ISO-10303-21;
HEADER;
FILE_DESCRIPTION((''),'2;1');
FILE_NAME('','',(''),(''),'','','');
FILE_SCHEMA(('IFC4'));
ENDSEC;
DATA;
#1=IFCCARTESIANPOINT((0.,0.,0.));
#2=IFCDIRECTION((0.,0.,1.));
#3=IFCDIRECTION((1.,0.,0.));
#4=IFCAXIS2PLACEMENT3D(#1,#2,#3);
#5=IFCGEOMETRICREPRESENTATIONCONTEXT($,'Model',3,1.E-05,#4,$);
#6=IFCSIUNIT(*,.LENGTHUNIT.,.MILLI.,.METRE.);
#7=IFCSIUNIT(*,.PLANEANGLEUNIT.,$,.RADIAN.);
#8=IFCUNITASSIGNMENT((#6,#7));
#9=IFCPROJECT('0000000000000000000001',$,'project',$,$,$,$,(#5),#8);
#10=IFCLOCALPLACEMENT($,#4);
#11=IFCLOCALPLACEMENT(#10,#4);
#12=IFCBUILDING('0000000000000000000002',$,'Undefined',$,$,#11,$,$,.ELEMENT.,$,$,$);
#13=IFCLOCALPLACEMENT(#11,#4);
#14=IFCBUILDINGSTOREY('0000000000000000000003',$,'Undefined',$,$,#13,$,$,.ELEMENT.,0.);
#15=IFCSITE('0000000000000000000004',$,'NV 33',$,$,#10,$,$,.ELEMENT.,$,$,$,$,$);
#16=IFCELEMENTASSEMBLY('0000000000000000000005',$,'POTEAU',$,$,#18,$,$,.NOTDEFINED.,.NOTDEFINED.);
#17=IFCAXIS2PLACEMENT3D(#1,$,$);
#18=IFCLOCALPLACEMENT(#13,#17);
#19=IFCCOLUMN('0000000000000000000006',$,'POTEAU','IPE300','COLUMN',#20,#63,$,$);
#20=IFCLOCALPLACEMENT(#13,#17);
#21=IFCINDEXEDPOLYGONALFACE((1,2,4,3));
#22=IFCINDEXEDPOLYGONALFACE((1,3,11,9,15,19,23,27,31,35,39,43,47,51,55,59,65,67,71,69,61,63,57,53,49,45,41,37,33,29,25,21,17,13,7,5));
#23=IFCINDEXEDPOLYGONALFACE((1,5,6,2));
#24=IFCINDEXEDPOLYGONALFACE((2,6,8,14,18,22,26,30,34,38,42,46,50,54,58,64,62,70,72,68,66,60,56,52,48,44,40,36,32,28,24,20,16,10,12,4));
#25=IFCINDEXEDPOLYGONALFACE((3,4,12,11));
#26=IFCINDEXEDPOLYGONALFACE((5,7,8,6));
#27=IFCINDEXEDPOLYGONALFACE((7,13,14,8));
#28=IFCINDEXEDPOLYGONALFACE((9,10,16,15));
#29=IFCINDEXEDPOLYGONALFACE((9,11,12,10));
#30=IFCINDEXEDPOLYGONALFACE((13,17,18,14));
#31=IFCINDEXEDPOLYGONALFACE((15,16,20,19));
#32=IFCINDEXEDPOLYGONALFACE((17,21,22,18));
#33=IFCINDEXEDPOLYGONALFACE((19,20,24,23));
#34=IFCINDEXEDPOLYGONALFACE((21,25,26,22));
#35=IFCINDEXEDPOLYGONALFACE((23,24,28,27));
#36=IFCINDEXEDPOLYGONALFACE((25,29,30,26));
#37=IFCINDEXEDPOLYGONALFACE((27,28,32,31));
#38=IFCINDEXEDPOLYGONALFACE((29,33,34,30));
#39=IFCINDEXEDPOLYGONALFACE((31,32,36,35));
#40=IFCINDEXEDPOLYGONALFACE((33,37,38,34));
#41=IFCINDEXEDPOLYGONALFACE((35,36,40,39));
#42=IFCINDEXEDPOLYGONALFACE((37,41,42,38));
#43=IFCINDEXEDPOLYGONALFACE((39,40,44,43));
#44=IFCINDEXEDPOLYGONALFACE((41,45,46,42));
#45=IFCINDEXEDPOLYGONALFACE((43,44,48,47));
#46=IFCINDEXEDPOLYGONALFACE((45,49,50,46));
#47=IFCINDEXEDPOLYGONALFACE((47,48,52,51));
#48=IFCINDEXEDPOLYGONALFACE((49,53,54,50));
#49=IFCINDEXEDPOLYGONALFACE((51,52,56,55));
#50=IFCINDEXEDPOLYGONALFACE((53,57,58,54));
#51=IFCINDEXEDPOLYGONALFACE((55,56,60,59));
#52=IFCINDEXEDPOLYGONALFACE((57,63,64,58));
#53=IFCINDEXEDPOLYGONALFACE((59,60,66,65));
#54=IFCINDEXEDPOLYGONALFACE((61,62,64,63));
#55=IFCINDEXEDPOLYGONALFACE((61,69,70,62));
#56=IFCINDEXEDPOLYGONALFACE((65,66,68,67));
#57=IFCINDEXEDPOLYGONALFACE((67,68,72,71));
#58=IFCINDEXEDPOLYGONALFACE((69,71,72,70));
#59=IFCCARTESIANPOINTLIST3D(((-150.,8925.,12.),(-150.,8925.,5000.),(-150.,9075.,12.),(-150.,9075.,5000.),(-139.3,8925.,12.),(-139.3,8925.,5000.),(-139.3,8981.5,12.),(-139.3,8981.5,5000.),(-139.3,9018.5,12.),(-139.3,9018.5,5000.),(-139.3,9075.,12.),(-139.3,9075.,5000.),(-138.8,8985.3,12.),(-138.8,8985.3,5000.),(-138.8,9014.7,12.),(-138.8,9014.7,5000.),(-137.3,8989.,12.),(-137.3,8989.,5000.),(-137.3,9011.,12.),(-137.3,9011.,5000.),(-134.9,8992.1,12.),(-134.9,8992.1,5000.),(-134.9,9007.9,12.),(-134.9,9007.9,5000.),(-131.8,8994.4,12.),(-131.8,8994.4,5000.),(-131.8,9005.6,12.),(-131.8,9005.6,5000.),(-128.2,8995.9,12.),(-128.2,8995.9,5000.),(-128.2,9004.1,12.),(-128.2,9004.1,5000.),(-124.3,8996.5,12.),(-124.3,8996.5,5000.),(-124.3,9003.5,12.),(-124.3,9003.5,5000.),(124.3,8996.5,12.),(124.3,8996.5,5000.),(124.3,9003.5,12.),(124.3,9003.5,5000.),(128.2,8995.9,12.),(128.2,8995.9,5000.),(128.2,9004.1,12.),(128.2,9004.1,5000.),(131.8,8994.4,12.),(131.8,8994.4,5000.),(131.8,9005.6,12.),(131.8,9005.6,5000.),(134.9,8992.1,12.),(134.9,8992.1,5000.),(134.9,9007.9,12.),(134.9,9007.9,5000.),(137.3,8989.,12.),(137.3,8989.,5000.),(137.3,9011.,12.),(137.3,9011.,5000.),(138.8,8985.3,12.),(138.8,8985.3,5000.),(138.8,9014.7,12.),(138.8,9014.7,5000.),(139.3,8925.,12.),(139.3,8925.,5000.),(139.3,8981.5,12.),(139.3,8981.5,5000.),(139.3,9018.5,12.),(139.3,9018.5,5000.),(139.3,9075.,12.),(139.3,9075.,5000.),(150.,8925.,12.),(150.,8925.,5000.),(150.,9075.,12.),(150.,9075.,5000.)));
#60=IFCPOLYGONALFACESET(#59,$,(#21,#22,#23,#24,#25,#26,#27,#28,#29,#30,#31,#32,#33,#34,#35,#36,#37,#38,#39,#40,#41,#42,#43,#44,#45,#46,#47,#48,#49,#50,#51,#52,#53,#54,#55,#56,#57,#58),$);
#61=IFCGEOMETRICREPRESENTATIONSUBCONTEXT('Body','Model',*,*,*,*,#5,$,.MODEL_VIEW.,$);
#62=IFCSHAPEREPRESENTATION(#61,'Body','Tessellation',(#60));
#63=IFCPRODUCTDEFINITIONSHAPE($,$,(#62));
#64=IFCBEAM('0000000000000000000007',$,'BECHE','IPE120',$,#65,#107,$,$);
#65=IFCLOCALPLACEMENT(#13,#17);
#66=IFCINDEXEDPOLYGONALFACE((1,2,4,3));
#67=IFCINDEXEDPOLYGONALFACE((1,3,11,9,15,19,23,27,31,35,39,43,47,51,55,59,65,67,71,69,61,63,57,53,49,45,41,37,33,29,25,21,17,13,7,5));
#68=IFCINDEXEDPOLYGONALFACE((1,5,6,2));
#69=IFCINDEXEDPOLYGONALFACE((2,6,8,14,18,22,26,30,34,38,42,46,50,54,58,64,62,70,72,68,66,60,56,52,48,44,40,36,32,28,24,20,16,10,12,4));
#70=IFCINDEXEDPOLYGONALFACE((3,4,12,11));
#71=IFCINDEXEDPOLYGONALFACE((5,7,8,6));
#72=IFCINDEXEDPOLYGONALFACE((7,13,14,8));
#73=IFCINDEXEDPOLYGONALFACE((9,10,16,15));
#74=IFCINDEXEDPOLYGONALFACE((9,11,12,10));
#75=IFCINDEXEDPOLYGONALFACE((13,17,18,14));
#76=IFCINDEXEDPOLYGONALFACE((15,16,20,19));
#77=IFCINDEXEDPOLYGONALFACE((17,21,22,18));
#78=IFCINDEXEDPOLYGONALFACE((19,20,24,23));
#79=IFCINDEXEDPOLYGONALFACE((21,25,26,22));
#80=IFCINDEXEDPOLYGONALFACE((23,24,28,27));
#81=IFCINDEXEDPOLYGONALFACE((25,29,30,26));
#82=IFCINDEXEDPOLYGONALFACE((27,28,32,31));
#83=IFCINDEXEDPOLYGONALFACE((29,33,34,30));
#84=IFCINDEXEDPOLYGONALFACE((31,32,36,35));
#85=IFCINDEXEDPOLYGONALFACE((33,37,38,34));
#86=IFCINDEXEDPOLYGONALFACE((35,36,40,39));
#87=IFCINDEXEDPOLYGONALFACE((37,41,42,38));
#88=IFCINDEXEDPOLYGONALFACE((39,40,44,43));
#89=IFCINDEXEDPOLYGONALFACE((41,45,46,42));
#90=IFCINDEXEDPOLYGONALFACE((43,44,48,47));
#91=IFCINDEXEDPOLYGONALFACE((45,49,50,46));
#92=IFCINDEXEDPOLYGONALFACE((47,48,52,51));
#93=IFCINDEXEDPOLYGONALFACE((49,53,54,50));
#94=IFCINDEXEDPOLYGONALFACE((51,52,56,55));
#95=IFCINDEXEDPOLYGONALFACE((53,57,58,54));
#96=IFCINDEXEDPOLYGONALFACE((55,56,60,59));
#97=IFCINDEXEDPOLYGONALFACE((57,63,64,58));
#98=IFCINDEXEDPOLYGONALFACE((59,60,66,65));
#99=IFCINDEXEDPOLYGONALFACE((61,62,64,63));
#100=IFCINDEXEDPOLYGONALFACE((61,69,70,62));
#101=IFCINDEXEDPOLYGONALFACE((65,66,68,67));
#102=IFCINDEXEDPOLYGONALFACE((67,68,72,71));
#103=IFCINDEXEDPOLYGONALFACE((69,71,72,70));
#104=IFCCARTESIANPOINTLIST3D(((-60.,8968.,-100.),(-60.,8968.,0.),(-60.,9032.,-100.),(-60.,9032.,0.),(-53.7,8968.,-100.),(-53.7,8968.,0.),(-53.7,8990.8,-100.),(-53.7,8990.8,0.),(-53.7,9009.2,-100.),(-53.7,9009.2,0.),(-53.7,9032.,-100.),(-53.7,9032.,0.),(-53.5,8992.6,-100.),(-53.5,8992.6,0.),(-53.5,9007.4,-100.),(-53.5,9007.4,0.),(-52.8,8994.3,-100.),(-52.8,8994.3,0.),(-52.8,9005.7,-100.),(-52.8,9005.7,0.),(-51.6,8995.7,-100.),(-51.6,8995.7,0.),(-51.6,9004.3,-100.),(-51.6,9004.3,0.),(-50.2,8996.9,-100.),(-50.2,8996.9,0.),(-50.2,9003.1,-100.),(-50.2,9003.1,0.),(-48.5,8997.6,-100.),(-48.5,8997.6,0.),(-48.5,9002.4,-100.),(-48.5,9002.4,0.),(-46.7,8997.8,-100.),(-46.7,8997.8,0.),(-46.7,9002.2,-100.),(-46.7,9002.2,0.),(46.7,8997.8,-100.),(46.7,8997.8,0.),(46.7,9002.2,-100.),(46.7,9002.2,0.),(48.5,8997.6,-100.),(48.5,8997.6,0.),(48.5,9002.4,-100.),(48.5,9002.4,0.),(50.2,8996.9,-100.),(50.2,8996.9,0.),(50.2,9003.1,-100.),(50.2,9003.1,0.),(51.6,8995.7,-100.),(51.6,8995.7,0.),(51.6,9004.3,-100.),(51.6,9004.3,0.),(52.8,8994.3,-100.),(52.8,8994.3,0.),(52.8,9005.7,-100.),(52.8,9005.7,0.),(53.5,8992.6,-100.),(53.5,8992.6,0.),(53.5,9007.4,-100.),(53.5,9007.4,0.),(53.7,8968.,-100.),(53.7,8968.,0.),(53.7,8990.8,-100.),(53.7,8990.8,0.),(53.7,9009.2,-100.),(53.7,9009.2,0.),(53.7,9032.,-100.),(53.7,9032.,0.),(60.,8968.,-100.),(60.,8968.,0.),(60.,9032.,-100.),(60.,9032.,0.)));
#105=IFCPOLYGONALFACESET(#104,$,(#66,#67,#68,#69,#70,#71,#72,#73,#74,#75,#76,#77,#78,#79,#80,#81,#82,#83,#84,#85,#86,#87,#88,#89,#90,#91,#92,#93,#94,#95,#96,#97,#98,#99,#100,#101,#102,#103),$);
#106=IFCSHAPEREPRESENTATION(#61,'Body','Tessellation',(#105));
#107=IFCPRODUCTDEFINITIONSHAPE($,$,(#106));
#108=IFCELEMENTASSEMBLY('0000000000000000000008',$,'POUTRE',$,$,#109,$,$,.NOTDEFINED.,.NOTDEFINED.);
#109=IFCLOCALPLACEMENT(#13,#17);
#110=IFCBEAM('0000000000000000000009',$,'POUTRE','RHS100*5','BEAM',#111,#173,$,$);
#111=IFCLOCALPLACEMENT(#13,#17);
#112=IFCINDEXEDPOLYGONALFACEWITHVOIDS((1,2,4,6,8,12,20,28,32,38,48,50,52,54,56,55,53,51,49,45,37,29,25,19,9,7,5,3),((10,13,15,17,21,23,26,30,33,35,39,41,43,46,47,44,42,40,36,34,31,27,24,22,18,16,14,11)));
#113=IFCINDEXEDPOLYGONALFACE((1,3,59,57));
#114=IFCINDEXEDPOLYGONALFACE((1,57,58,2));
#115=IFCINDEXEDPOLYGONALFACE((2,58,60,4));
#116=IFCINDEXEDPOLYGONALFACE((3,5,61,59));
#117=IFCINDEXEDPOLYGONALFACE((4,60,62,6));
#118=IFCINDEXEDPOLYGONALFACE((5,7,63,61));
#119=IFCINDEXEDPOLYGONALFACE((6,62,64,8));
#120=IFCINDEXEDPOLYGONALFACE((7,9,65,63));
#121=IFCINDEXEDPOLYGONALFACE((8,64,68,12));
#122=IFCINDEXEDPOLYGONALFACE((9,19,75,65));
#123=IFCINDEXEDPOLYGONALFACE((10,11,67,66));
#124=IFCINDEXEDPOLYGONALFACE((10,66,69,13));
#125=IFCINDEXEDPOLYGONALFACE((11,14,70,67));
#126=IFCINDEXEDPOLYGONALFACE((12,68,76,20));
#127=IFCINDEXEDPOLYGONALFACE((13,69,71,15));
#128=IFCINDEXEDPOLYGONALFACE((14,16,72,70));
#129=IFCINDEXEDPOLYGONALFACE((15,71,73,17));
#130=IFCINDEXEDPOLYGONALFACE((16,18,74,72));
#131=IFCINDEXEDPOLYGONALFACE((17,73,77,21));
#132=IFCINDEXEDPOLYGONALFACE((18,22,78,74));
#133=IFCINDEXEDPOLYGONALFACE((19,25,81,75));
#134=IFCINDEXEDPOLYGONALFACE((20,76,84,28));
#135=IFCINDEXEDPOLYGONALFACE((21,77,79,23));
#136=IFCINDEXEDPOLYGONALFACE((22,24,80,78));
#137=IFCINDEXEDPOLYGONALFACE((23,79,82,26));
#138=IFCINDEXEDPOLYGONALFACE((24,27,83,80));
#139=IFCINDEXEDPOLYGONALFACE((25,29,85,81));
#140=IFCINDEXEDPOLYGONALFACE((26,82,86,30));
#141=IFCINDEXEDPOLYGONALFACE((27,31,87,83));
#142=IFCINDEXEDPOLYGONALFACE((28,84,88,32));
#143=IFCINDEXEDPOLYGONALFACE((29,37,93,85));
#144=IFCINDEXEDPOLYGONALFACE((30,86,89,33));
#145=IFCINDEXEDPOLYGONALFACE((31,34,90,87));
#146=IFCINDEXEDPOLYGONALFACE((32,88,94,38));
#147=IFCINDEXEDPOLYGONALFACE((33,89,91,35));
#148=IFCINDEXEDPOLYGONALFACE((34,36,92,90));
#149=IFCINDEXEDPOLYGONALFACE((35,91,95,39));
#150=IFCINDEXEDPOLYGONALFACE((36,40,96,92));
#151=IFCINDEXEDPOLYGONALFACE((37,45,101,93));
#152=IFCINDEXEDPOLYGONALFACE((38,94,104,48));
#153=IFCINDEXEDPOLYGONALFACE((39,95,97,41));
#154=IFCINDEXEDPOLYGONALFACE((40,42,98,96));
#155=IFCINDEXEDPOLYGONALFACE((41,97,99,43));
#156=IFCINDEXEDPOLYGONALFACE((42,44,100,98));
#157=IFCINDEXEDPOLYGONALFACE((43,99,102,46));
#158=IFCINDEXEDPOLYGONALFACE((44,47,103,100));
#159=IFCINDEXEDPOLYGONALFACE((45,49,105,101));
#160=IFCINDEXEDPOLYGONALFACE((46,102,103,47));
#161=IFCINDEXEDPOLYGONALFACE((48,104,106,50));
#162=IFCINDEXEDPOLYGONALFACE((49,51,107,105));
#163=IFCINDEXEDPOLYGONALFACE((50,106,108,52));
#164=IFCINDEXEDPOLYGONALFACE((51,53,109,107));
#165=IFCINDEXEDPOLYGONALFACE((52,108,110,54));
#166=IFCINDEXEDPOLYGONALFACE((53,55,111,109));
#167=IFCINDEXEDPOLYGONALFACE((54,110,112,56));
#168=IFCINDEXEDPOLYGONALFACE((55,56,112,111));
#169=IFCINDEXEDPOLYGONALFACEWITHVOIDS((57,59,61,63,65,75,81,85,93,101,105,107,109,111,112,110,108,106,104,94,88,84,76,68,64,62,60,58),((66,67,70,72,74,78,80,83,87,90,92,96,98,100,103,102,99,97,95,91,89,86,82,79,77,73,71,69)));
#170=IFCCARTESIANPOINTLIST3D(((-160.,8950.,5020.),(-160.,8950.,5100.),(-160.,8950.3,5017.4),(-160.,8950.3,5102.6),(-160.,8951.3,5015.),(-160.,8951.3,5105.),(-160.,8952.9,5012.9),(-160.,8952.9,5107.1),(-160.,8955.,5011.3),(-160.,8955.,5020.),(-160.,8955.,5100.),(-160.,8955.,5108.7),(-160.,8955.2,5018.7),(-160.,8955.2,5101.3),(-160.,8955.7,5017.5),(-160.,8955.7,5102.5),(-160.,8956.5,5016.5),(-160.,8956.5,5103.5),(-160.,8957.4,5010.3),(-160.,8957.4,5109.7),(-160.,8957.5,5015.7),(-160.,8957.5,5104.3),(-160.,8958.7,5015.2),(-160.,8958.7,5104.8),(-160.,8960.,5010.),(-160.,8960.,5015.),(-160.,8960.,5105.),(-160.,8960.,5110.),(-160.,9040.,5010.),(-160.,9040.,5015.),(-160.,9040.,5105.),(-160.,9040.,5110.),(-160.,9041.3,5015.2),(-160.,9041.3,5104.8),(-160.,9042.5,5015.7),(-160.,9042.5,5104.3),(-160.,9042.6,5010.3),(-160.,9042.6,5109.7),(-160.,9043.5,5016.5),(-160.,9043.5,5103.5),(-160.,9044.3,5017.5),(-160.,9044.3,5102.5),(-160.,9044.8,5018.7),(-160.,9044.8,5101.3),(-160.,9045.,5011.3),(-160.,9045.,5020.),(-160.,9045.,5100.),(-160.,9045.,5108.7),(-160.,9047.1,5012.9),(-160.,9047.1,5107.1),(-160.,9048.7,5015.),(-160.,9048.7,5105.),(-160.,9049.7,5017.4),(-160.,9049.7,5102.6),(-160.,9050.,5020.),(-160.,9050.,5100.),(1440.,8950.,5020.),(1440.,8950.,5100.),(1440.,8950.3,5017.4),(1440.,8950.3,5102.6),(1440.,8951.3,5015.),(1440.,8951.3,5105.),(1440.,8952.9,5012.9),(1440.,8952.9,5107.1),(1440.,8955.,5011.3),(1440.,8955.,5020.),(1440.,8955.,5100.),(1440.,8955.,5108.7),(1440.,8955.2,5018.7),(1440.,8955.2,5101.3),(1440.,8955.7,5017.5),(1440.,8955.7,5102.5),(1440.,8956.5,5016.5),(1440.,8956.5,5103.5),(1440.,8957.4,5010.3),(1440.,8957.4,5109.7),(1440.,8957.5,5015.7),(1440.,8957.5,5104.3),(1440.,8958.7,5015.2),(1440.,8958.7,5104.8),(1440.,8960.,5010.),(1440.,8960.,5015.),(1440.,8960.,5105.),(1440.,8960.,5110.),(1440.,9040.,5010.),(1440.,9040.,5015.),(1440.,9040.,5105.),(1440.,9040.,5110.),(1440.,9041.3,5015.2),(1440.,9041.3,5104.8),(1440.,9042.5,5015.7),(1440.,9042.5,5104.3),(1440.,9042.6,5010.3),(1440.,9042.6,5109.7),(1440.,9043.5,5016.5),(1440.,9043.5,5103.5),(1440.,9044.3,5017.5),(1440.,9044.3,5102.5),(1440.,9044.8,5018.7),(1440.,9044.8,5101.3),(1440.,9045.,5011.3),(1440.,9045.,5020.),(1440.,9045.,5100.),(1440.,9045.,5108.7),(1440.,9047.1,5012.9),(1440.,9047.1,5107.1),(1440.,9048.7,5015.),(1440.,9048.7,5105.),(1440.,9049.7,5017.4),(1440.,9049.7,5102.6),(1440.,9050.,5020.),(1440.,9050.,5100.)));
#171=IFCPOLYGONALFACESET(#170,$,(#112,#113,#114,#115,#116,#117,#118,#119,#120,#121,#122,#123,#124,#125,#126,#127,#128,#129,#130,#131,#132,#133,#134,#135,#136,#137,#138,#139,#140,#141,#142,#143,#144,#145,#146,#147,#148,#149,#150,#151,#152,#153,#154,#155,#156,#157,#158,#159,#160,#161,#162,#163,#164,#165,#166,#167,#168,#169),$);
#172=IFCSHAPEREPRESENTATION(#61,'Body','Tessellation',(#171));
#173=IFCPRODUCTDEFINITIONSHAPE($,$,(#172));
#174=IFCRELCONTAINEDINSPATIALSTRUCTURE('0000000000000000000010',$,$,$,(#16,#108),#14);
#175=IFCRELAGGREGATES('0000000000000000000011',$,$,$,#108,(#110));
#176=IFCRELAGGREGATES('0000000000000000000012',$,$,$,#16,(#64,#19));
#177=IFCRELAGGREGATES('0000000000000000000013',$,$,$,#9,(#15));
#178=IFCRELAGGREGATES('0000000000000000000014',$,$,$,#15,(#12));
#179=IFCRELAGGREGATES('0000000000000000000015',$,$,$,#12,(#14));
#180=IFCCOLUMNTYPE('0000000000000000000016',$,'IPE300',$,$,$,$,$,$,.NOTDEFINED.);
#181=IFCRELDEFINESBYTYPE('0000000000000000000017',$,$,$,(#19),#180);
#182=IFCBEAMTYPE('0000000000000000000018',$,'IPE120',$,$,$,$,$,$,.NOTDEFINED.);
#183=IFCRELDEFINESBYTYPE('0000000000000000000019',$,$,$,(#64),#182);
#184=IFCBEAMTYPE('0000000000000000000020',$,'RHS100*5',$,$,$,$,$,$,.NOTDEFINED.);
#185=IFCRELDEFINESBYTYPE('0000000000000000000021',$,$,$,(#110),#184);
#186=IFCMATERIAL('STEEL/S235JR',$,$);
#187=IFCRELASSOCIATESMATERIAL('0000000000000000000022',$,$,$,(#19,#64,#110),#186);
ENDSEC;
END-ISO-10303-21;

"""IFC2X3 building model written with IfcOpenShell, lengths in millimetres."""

from ifc_helpers import new_model, si_unit, frame, origin_with_axes, origin_2d_with_axis, place, context, subcontext, project, spatial, hollow_rectangle, i_section, extrude, clip, halfspace, material, type_object, element, aggregate, save


model = new_model("IFC2X3")

# Units and contexts
model_context = context("Model", 3, precision=1e-05, world=origin_with_axes())
body_context = subcontext(model_context, "Body", "Model", "MODEL_VIEW")
ifc_project = project(units=[si_unit("LENGTHUNIT", "METRE", prefix="MILLI"), si_unit("PLANEANGLEUNIT", "RADIAN")], contexts=[model_context])

# Site, building, storey
site_placement = place(None, origin_with_axes())
site = spatial("IfcSite", under=ifc_project, at=site_placement, Name="NV 33", CompositionType="ELEMENT")
building_placement = place(site_placement, origin_with_axes())
building = spatial("IfcBuilding", under=site, at=building_placement, Name="Undefined", CompositionType="ELEMENT")
storey_placement = place(building_placement, origin_with_axes())
storey = spatial("IfcBuildingStorey", under=building, at=storey_placement, Name="Undefined", CompositionType="ELEMENT", Elevation=0.0)

# Element assembly, column
assembly_1_placement = place(storey_placement, origin_with_axes())
assembly_1 = element("IfcElementAssembly", 1, at=assembly_1_placement, inside=storey, Name="POTEAU", AssemblyPlace="NOTDEFINED", PredefinedType="NOTDEFINED")
ifc_material_1 = material(Name="STEEL/S235JR")
column_type = type_object("IfcColumnType", Name="IPE300", PredefinedType="NOTDEFINED")
column_placement = place(assembly_1_placement, frame((0.0, 9000.0, 0.0), z_axis=(0.0, 0.0, 1.0), x_axis=(-1.0, 0.0, 0.0)))
column = element("IfcColumn", 2, at=column_placement, type_object=column_type, material=ifc_material_1, Name="POTEAU", Description="IPE300", ObjectType="COLUMN", context=body_context, shape_type="Clipping", body=[
    clip(clip(extrude(i_section(OverallWidth=150.0, OverallDepth=300.0, WebThickness=7.1, FlangeThickness=10.7, FilletRadius=15.0, at=origin_2d_with_axis()), frame((0.0, 0.0, 5000.0), z_axis=(0.0, 0.0, -1.0), x_axis=(0.0, 1.0, 0.0)), (0.0, 0.0, 1.0), 5000.0), halfspace(frame((-150.0, 0.0, 5000.0), z_axis=(0.0, 0.0, -1.0), x_axis=(0.0, -1.0, 0.0)), True)), halfspace(frame((-150.0, 0.0, 12.0), z_axis=(0.0, 0.0, 1.0), x_axis=(0.0, 1.0, 0.0)), True)),
])

# Beam
beam_type_1 = type_object("IfcBeamType", Name="IPE120", PredefinedType="NOTDEFINED")
beam_1_placement = place(assembly_1_placement, frame((0.0, 9000.0, 0.0), z_axis=(-1.0, 0.0, 0.0), x_axis=(0.0, 0.0, -1.0)))
beam_1 = element("IfcBeam", 3, at=beam_1_placement, type_object=beam_type_1, material=ifc_material_1, Name="BECHE", Description="IPE120", context=body_context, shape_type="SweptSolid", body=[
    extrude(i_section(OverallWidth=64.0, OverallDepth=120.0, WebThickness=4.4, FlangeThickness=6.3, FilletRadius=7.0, at=origin_2d_with_axis()), frame((100.0, 0.0, 0.0), z_axis=(-1.0, 0.0, 0.0), x_axis=(0.0, -1.0, 0.0)), (0.0, 0.0, 1.0), 100.0),
])

# Element assembly, beam
assembly_2_placement = place(storey_placement, origin_with_axes())
assembly_2 = element("IfcElementAssembly", 4, at=assembly_2_placement, inside=storey, Name="POUTRE", AssemblyPlace="NOTDEFINED", PredefinedType="NOTDEFINED")
beam_type_2 = type_object("IfcBeamType", Name="RHS100*5", PredefinedType="NOTDEFINED")
beam_2_placement = place(assembly_2_placement, frame((-160.0, 9000.0, 5060.0), z_axis=(0.0, -1.0, 0.0), x_axis=(1.0, 0.0, 0.0)))
beam_2 = element("IfcBeam", 5, at=beam_2_placement, type_object=beam_type_2, material=ifc_material_1, Name="POUTRE", Description="RHS100*5", ObjectType="BEAM", context=body_context, shape_type="SweptSolid", body=[
    extrude(hollow_rectangle(XDim=100.0, YDim=100.0, WallThickness=5.0, InnerFilletRadius=5.0, OuterFilletRadius=10.0, at=origin_2d_with_axis()), frame((1600.0, 0.0, 0.0), z_axis=(-1.0, 0.0, 0.0), x_axis=(0.0, -1.0, 0.0)), (0.0, 0.0, 1.0), 1600.0),
])
aggregate(assembly_2, [beam_2])

aggregate(assembly_1, [beam_1, column])

save(model, "model.ifc")
